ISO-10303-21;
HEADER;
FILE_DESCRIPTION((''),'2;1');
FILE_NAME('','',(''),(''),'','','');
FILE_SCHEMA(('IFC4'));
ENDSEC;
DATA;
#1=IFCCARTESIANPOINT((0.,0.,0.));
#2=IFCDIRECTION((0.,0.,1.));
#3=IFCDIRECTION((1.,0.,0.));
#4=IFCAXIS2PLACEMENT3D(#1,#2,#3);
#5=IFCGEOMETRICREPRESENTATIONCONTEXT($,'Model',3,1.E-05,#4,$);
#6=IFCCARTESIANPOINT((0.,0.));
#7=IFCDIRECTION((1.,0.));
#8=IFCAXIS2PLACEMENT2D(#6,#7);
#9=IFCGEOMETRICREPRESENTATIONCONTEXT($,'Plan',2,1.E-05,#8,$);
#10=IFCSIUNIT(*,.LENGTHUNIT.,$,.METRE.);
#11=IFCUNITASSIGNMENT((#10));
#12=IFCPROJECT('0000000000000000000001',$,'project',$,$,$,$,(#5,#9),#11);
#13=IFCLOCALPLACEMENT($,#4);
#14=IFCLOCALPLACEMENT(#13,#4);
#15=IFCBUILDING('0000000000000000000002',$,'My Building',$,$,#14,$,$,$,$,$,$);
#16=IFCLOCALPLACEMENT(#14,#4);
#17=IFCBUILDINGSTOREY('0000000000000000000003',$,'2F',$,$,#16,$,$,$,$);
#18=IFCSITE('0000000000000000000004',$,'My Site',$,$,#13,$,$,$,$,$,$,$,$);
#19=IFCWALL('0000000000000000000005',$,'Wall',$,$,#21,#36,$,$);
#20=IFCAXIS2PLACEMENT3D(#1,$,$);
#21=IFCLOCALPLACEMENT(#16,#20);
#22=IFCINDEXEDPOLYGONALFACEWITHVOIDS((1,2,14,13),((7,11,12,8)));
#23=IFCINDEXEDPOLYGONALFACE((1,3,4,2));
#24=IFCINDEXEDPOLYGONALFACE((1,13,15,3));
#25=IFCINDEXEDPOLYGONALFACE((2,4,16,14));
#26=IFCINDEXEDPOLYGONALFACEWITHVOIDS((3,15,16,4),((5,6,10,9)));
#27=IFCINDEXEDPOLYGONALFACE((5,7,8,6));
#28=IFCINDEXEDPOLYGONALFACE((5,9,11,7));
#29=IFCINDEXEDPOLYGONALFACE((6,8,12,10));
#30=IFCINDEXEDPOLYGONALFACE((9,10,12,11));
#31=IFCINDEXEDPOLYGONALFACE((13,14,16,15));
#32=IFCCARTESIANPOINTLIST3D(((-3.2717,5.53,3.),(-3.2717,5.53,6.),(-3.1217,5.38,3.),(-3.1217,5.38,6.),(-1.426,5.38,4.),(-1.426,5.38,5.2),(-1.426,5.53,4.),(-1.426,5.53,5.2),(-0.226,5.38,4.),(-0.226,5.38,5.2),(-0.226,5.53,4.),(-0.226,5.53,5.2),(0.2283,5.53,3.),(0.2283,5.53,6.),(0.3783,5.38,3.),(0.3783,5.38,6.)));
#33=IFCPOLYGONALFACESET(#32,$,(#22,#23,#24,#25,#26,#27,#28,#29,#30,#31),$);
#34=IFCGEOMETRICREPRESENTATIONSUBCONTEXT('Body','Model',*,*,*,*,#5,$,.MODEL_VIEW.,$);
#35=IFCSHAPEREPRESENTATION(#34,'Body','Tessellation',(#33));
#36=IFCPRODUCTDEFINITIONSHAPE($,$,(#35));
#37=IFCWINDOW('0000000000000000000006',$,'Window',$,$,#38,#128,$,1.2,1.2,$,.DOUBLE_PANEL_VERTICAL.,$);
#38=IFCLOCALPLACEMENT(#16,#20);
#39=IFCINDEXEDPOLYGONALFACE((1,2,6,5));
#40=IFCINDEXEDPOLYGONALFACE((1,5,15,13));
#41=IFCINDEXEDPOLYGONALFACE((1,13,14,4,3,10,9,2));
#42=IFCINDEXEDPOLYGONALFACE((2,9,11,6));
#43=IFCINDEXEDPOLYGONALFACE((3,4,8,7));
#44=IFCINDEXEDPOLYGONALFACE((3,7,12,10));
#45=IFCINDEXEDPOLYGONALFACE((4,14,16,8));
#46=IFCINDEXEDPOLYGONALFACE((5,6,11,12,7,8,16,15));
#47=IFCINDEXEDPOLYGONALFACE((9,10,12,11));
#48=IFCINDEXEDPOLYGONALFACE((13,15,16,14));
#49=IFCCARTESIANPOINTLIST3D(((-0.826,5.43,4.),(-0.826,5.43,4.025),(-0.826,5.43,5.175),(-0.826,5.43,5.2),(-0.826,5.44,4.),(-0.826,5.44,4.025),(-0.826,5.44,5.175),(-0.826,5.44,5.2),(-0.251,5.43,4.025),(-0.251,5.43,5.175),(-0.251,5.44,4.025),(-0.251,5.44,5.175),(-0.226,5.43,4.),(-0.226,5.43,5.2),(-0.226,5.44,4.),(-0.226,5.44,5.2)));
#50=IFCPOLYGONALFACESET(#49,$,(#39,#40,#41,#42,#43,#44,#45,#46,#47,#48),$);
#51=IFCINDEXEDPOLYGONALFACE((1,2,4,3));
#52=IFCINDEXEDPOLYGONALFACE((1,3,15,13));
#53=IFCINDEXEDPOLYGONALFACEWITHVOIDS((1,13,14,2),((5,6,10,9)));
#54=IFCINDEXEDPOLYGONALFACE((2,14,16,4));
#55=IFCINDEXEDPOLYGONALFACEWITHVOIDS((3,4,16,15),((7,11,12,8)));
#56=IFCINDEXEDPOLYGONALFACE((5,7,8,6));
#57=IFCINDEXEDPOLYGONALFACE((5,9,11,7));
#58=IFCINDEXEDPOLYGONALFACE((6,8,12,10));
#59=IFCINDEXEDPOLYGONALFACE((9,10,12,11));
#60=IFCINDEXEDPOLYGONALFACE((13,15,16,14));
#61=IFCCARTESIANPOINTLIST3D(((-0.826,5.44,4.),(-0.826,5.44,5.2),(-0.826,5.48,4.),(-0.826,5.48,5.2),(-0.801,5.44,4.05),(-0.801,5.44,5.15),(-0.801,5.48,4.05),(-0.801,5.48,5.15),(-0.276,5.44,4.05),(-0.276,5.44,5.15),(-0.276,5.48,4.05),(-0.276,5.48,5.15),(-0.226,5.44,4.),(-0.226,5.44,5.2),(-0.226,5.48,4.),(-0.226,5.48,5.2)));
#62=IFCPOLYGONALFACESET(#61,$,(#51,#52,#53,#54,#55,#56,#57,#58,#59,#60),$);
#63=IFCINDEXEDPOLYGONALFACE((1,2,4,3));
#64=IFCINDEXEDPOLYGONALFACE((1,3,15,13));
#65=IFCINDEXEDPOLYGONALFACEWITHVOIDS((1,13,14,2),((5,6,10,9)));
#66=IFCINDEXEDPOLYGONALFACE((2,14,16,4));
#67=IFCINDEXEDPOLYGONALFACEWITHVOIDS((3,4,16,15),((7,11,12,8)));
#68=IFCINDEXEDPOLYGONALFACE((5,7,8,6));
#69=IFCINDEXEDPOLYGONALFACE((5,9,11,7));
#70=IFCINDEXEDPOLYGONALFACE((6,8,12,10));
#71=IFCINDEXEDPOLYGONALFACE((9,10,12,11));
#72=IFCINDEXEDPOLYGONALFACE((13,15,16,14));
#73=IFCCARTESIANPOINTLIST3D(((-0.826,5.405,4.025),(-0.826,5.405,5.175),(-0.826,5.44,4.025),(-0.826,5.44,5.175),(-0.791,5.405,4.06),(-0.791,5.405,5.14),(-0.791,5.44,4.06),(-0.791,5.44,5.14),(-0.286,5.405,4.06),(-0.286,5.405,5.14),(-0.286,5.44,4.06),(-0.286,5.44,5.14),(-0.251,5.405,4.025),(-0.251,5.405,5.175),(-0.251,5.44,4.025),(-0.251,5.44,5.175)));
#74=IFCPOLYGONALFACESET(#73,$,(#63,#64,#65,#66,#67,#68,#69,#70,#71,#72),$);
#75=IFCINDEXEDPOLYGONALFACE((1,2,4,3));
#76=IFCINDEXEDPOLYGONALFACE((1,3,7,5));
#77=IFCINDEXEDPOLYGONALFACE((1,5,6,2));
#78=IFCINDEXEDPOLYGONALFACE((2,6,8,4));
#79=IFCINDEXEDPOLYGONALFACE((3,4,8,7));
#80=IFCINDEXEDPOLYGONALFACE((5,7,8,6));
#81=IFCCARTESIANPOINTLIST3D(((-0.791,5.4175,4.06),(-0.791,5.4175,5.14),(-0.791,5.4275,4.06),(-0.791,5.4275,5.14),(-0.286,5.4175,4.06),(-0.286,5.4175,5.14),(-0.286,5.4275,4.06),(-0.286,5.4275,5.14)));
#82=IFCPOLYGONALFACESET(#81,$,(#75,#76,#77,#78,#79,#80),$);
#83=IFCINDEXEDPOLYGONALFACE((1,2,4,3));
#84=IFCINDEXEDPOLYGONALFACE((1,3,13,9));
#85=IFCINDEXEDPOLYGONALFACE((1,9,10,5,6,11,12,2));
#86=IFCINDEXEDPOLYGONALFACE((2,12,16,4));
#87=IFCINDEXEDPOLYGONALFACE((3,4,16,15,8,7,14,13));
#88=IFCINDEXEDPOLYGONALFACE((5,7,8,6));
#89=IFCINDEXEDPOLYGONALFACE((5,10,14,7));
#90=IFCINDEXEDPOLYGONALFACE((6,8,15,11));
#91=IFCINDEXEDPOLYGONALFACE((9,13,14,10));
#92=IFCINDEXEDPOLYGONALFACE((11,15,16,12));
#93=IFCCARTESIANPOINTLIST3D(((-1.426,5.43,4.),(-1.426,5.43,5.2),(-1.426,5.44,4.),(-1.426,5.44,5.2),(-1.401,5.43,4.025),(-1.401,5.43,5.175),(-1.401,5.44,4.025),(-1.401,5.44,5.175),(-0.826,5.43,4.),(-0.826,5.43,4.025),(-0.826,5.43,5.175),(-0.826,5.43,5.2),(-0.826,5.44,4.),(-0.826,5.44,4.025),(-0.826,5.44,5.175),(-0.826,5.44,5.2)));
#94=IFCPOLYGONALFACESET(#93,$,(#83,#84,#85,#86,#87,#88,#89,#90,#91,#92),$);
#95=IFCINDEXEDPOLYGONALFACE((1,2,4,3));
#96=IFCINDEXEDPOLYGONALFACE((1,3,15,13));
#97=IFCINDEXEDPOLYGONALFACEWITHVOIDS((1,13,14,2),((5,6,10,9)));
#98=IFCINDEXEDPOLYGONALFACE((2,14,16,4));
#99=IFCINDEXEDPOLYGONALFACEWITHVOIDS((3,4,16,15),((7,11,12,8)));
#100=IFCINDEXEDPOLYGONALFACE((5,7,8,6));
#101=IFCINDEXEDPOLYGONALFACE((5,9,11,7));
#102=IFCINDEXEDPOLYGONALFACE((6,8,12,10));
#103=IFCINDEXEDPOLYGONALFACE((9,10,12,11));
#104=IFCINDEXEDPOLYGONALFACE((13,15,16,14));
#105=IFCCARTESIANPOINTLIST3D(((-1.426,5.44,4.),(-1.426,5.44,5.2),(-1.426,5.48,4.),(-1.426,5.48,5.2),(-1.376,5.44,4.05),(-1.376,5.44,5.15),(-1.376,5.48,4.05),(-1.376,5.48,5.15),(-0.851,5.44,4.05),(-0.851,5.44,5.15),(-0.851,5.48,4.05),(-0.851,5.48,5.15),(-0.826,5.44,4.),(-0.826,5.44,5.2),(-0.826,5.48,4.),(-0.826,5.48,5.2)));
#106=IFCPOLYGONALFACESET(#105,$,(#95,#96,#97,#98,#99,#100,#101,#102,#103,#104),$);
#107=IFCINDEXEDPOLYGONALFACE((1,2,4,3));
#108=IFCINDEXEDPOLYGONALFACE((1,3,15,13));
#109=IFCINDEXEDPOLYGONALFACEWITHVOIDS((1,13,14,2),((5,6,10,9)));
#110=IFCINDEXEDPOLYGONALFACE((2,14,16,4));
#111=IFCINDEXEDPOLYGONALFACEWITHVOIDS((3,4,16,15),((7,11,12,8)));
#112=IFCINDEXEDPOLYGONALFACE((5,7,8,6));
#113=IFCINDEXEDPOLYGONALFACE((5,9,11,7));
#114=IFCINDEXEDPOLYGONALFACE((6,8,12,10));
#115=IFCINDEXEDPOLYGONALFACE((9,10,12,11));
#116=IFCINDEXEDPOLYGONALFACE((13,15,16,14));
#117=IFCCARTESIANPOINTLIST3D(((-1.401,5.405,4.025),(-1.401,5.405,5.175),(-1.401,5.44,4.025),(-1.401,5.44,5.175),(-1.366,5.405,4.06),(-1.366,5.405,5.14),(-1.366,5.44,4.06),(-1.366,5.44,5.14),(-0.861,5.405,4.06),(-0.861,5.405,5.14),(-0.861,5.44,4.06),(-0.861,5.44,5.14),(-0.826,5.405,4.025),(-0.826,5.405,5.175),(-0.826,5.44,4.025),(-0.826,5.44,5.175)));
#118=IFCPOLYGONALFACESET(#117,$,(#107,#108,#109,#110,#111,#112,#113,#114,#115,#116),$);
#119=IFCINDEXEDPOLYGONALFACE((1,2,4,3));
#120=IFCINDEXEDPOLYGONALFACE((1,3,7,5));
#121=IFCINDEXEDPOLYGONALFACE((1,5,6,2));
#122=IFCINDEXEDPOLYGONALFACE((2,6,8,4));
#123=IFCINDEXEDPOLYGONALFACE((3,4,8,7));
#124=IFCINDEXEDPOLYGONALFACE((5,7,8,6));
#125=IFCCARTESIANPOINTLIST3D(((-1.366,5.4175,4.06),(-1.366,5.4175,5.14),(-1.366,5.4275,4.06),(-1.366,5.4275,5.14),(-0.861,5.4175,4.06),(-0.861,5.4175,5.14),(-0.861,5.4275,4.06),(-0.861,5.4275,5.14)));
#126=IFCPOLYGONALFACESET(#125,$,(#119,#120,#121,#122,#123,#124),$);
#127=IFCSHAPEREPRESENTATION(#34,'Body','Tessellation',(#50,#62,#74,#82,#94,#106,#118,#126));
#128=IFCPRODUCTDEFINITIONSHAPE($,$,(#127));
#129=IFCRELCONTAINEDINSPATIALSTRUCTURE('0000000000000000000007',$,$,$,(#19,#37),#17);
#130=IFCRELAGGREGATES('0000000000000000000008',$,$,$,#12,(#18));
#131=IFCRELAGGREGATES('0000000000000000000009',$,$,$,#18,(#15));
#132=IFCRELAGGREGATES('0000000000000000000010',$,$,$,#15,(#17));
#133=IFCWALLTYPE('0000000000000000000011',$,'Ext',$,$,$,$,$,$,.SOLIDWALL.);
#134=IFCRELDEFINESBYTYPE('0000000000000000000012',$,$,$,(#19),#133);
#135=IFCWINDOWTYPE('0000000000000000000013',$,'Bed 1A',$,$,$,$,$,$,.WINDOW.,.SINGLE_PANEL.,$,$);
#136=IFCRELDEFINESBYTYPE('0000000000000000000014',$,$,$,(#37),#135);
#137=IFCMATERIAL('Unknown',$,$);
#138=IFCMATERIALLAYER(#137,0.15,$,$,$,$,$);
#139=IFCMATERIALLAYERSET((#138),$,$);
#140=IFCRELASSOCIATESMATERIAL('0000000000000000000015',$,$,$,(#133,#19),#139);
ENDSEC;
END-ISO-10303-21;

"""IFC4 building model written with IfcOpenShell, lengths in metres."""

from ifc_helpers import new_model, entity, si_unit, frame, origin_with_axes, origin_2d_with_axis, place, context, subcontext, project, spatial, line, indexed_curve, outline, extrude, shape, source, transform, mapped, material, layer, layer_set, layer_usage, type_object, type_shapes, element, fill, save


model = new_model("IFC4")

# Units and contexts
model_context = context("Model", 3, precision=1e-05, world=origin_with_axes())
plan_context = context("Plan", 2, precision=1e-05, world=origin_2d_with_axis())
body_context_1 = subcontext(model_context, "Body", "Model", "MODEL_VIEW")
body_context_2 = subcontext(plan_context, "Body", "Plan", "PLAN_VIEW")
ifc_project = project(units=[si_unit("LENGTHUNIT", "METRE")], contexts=[model_context, plan_context])

# Site, building, storey
site_placement = place(None, origin_with_axes())
site = spatial("IfcSite", under=ifc_project, at=site_placement, Name="My Site")
building_placement = place(site_placement, origin_with_axes())
building = spatial("IfcBuilding", under=site, at=building_placement, Name="My Building")
storey_placement = place(building_placement, origin_with_axes())
storey = spatial("IfcBuildingStorey", under=building, at=storey_placement, Name="2F")

# Shared definitions
ifc_material = material(Name="Unknown")
ifc_layer_1 = layer(ifc_material, 0.15)
ifc_layer_set_1 = layer_set([ifc_layer_1])
wall_type_1 = type_object("IfcWallType", Name="Ext", PredefinedType="SOLIDWALL", material=ifc_layer_set_1)

# Wall, opening, window
ifc_layer_usage_1 = layer_usage(ifc_layer_set_1, "AXIS2", "POSITIVE", 0.0)
wall_1_placement = place(storey_placement, frame((0.2283, 5.53, 3.0), z_axis=(0.0, 0.0, 1.0), x_axis=(-1.0, 0.0, 0.0)))
wall_1 = element("IfcWall", 1, at=wall_1_placement, inside=storey, type_object=wall_type_1, material=ifc_layer_usage_1, Name="Wall", context=body_context_1, shape_type="SweptSolid", body=[
    extrude(outline(indexed_curve([(0.0, 0.0), (-0.15, 0.15), (3.35, 0.15), (3.5, 0.0)], segments=[line(1, 2, 3, 4, 1)])), origin_with_axes(), (0.0, 0.0, 1.0), 3.0),
])
shared_shape_1 = source(origin_with_axes(), body_context_1, "Body", "SweptSolid", [
    extrude(outline(indexed_curve([(0.0, 0.0), (1.2, 0.0), (1.2, 1.2), (0.0, 1.2)], segments=[line(1, 2, 3, 4, 1)])), frame((0.0, -0.6, 0.0), z_axis=(0.0, -1.0, 0.0), x_axis=(1.0, 0.0, 0.0)), (0.0, 0.0, -1.0), 1.2),
])
opening_1_placement = place(wall_1_placement, frame((0.4544, 0.0, 1.0), z_axis=(0.0, 0.0, 1.0), x_axis=(1.0, 0.0, 0.0)))
opening_1 = element("IfcOpeningElement", 2, at=opening_1_placement, cuts=wall_1, PredefinedType="OPENING", context=body_context_1, shape_type="MappedRepresentation", body=[
    mapped(shared_shape_1, transform((0.0, 0.0, 0.0), x_axis=(1.0, 0.0, 0.0), y_axis=(0.0, 1.0, 0.0), z_axis=(0.0, 0.0, 1.0), scale=1.0)),
])
window_type_1 = type_object("IfcWindowType", Name="Bed 1A", PartitioningType="SINGLE_PANEL", PredefinedType="WINDOW")
shared_shape_2 = source(origin_with_axes(), body_context_1, "Body", "SweptSolid", [
    extrude(outline(indexed_curve([(0.6, 0.0), (0.0, 0.0), (0.0, 1.2), (0.6, 1.2), (0.6, 1.175), (0.025, 1.175), (0.025, 0.025), (0.6, 0.025)], segments=[line(1, 2, 3, 4, 5, 6, 7, 8, 1)])), frame((0.0, 0.09, 0.0), z_axis=(0.0, -1.0, 0.0), x_axis=(1.0, 0.0, 0.0)), (0.0, 0.0, -1.0), 0.01),
    extrude(outline(indexed_curve([(0.0, 0.0), (0.6, 0.0), (0.6, 1.2), (0.0, 1.2)], segments=[line(1, 2, 3, 4, 1)]), holes=[indexed_curve([(0.05, 0.05), (0.575, 0.05), (0.575, 1.15), (0.05, 1.15)], segments=[line(1, 2, 3, 4, 1)])]), frame((0.0, 0.05, 0.0), z_axis=(0.0, -1.0, 0.0), x_axis=(1.0, 0.0, 0.0)), (0.0, 0.0, -1.0), 0.04),
    extrude(outline(indexed_curve([(0.0, 0.0), (0.575, 0.0), (0.575, 1.15), (0.0, 1.15)], segments=[line(1, 2, 3, 4, 1)]), holes=[indexed_curve([(0.035, 0.035), (0.54, 0.035), (0.54, 1.115), (0.035, 1.115)], segments=[line(1, 2, 3, 4, 1)])]), frame((0.025, 0.09, 0.025), z_axis=(0.0, -1.0, 0.0), x_axis=(1.0, 0.0, 0.0)), (0.0, 0.0, -1.0), 0.035),
    extrude(outline(indexed_curve([(0.035, 0.035), (0.54, 0.035), (0.54, 1.115), (0.035, 1.115)], segments=[line(1, 2, 3, 4, 1)])), frame((0.025, 0.1025, 0.025), z_axis=(0.0, -1.0, 0.0), x_axis=(1.0, 0.0, 0.0)), (0.0, 0.0, -1.0), 0.01),
    extrude(outline(indexed_curve([(0.0, 1.2), (0.6, 1.2), (0.6, 0.0), (0.0, 0.0), (0.0, 0.025), (0.575, 0.025), (0.575, 1.175), (0.0, 1.175)], segments=[line(1, 2, 3, 4, 5, 6, 7, 8, 1)])), frame((0.6, 0.09, 0.0), z_axis=(0.0, -1.0, 0.0), x_axis=(1.0, 0.0, 0.0)), (0.0, 0.0, -1.0), 0.01),
    extrude(outline(indexed_curve([(0.0, 0.0), (0.6, 0.0), (0.6, 1.2), (0.0, 1.2)], segments=[line(1, 2, 3, 4, 1)]), holes=[indexed_curve([(0.025, 0.05), (0.55, 0.05), (0.55, 1.15), (0.025, 1.15)], segments=[line(1, 2, 3, 4, 1)])]), frame((0.6, 0.05, 0.0), z_axis=(0.0, -1.0, 0.0), x_axis=(1.0, 0.0, 0.0)), (0.0, 0.0, -1.0), 0.04),
    extrude(outline(indexed_curve([(0.0, 0.0), (0.575, 0.0), (0.575, 1.15), (0.0, 1.15)], segments=[line(1, 2, 3, 4, 1)]), holes=[indexed_curve([(0.035, 0.035), (0.54, 0.035), (0.54, 1.115), (0.035, 1.115)], segments=[line(1, 2, 3, 4, 1)])]), frame((0.6, 0.09, 0.025), z_axis=(0.0, -1.0, 0.0), x_axis=(1.0, 0.0, 0.0)), (0.0, 0.0, -1.0), 0.035),
    extrude(outline(indexed_curve([(0.035, 0.035), (0.54, 0.035), (0.54, 1.115), (0.035, 1.115)], segments=[line(1, 2, 3, 4, 1)])), frame((0.6, 0.1025, 0.025), z_axis=(0.0, -1.0, 0.0), x_axis=(1.0, 0.0, 0.0)), (0.0, 0.0, -1.0), 0.01),
])
shared_shape_3 = source(origin_with_axes(), body_context_2, "Body", "Curve2D", [
    entity("IfcIndexedPolyCurve", entity("IfcCartesianPointList2D", [[0.05, 0.05], [0.575, 0.05]])),
    entity("IfcIndexedPolyCurve", entity("IfcCartesianPointList2D", [[0.0, 0.1], [0.025, 0.1], [0.025, 0.09], [0.05, 0.09], [0.05, 0.05], [0.0, 0.05]]), [entity("IfcLineIndex", [1, 2, 3, 4, 5, 6, 1])]),
    entity("IfcIndexedPolyCurve", entity("IfcCartesianPointList2D", [[0.6, 0.1], [0.6, 0.1], [0.6, 0.09], [0.575, 0.09], [0.575, 0.05], [0.6, 0.05]])),
    entity("IfcIndexedPolyCurve", entity("IfcCartesianPointList2D", [[0.025, 0.09], [0.06, 0.09], [0.06, 0.125], [0.025, 0.125]]), [entity("IfcLineIndex", [1, 2, 3, 4, 1])]),
    entity("IfcIndexedPolyCurve", entity("IfcCartesianPointList2D", [[0.6, 0.09], [0.565, 0.09], [0.565, 0.125], [0.6, 0.125]]), [entity("IfcLineIndex", [1, 2, 3, 4, 1])]),
    entity("IfcIndexedPolyCurve", entity("IfcCartesianPointList2D", [[0.06, 0.09], [0.565, 0.09]])),
    entity("IfcIndexedPolyCurve", entity("IfcCartesianPointList2D", [[0.06, 0.125], [0.565, 0.125]])),
    entity("IfcIndexedPolyCurve", entity("IfcCartesianPointList2D", [[0.06, 0.1075], [0.565, 0.1075]])),
    entity("IfcIndexedPolyCurve", entity("IfcCartesianPointList2D", [[0.625, 0.05], [1.15, 0.05]])),
    entity("IfcIndexedPolyCurve", entity("IfcCartesianPointList2D", [[0.6, 0.1], [0.6, 0.1], [0.6, 0.09], [0.625, 0.09], [0.625, 0.05], [0.6, 0.05]])),
    entity("IfcIndexedPolyCurve", entity("IfcCartesianPointList2D", [[1.2, 0.1], [1.175, 0.1], [1.175, 0.09], [1.15, 0.09], [1.15, 0.05], [1.2, 0.05]]), [entity("IfcLineIndex", [1, 2, 3, 4, 5, 6, 1])]),
    entity("IfcIndexedPolyCurve", entity("IfcCartesianPointList2D", [[0.6, 0.09], [0.635, 0.09], [0.635, 0.125], [0.6, 0.125]]), [entity("IfcLineIndex", [1, 2, 3, 4, 1])]),
    entity("IfcIndexedPolyCurve", entity("IfcCartesianPointList2D", [[1.175, 0.09], [1.14, 0.09], [1.14, 0.125], [1.175, 0.125]]), [entity("IfcLineIndex", [1, 2, 3, 4, 1])]),
    entity("IfcIndexedPolyCurve", entity("IfcCartesianPointList2D", [[0.635, 0.09], [1.14, 0.09]])),
    entity("IfcIndexedPolyCurve", entity("IfcCartesianPointList2D", [[0.635, 0.125], [1.14, 0.125]])),
    entity("IfcIndexedPolyCurve", entity("IfcCartesianPointList2D", [[0.635, 0.1075], [1.14, 0.1075]])),
])
type_shapes(window_type_1, [shared_shape_2, shared_shape_3])
window_1_placement = place(opening_1_placement, frame((0.0, 0.0, 0.0), z_axis=(0.0, 0.0, 1.0), x_axis=(1.0, 0.0, 0.0)))
window_1 = element("IfcWindow", 3, at=window_1_placement, inside=storey, type_object=window_type_1, Name="Window", OverallHeight=1.2, OverallWidth=1.2, PartitioningType="DOUBLE_PANEL_VERTICAL", shapes=[
    shape(body_context_1, "Body", "MappedRepresentation", [mapped(shared_shape_2, transform((0.0, 0.0, 0.0), x_axis=(1.0, 0.0, 0.0), y_axis=(0.0, 1.0, 0.0), z_axis=(0.0, 0.0, 1.0), scale=1.0))]),
    shape(body_context_2, "Body", "MappedRepresentation", [mapped(shared_shape_3, transform((0.0, 0.0, 0.0), x_axis=(1.0, 0.0, 0.0), y_axis=(0.0, 1.0, 0.0), z_axis=(0.0, 0.0, 1.0), scale=1.0))]),
])
fill(opening_1, window_1)

save(model, "model.ifc")
